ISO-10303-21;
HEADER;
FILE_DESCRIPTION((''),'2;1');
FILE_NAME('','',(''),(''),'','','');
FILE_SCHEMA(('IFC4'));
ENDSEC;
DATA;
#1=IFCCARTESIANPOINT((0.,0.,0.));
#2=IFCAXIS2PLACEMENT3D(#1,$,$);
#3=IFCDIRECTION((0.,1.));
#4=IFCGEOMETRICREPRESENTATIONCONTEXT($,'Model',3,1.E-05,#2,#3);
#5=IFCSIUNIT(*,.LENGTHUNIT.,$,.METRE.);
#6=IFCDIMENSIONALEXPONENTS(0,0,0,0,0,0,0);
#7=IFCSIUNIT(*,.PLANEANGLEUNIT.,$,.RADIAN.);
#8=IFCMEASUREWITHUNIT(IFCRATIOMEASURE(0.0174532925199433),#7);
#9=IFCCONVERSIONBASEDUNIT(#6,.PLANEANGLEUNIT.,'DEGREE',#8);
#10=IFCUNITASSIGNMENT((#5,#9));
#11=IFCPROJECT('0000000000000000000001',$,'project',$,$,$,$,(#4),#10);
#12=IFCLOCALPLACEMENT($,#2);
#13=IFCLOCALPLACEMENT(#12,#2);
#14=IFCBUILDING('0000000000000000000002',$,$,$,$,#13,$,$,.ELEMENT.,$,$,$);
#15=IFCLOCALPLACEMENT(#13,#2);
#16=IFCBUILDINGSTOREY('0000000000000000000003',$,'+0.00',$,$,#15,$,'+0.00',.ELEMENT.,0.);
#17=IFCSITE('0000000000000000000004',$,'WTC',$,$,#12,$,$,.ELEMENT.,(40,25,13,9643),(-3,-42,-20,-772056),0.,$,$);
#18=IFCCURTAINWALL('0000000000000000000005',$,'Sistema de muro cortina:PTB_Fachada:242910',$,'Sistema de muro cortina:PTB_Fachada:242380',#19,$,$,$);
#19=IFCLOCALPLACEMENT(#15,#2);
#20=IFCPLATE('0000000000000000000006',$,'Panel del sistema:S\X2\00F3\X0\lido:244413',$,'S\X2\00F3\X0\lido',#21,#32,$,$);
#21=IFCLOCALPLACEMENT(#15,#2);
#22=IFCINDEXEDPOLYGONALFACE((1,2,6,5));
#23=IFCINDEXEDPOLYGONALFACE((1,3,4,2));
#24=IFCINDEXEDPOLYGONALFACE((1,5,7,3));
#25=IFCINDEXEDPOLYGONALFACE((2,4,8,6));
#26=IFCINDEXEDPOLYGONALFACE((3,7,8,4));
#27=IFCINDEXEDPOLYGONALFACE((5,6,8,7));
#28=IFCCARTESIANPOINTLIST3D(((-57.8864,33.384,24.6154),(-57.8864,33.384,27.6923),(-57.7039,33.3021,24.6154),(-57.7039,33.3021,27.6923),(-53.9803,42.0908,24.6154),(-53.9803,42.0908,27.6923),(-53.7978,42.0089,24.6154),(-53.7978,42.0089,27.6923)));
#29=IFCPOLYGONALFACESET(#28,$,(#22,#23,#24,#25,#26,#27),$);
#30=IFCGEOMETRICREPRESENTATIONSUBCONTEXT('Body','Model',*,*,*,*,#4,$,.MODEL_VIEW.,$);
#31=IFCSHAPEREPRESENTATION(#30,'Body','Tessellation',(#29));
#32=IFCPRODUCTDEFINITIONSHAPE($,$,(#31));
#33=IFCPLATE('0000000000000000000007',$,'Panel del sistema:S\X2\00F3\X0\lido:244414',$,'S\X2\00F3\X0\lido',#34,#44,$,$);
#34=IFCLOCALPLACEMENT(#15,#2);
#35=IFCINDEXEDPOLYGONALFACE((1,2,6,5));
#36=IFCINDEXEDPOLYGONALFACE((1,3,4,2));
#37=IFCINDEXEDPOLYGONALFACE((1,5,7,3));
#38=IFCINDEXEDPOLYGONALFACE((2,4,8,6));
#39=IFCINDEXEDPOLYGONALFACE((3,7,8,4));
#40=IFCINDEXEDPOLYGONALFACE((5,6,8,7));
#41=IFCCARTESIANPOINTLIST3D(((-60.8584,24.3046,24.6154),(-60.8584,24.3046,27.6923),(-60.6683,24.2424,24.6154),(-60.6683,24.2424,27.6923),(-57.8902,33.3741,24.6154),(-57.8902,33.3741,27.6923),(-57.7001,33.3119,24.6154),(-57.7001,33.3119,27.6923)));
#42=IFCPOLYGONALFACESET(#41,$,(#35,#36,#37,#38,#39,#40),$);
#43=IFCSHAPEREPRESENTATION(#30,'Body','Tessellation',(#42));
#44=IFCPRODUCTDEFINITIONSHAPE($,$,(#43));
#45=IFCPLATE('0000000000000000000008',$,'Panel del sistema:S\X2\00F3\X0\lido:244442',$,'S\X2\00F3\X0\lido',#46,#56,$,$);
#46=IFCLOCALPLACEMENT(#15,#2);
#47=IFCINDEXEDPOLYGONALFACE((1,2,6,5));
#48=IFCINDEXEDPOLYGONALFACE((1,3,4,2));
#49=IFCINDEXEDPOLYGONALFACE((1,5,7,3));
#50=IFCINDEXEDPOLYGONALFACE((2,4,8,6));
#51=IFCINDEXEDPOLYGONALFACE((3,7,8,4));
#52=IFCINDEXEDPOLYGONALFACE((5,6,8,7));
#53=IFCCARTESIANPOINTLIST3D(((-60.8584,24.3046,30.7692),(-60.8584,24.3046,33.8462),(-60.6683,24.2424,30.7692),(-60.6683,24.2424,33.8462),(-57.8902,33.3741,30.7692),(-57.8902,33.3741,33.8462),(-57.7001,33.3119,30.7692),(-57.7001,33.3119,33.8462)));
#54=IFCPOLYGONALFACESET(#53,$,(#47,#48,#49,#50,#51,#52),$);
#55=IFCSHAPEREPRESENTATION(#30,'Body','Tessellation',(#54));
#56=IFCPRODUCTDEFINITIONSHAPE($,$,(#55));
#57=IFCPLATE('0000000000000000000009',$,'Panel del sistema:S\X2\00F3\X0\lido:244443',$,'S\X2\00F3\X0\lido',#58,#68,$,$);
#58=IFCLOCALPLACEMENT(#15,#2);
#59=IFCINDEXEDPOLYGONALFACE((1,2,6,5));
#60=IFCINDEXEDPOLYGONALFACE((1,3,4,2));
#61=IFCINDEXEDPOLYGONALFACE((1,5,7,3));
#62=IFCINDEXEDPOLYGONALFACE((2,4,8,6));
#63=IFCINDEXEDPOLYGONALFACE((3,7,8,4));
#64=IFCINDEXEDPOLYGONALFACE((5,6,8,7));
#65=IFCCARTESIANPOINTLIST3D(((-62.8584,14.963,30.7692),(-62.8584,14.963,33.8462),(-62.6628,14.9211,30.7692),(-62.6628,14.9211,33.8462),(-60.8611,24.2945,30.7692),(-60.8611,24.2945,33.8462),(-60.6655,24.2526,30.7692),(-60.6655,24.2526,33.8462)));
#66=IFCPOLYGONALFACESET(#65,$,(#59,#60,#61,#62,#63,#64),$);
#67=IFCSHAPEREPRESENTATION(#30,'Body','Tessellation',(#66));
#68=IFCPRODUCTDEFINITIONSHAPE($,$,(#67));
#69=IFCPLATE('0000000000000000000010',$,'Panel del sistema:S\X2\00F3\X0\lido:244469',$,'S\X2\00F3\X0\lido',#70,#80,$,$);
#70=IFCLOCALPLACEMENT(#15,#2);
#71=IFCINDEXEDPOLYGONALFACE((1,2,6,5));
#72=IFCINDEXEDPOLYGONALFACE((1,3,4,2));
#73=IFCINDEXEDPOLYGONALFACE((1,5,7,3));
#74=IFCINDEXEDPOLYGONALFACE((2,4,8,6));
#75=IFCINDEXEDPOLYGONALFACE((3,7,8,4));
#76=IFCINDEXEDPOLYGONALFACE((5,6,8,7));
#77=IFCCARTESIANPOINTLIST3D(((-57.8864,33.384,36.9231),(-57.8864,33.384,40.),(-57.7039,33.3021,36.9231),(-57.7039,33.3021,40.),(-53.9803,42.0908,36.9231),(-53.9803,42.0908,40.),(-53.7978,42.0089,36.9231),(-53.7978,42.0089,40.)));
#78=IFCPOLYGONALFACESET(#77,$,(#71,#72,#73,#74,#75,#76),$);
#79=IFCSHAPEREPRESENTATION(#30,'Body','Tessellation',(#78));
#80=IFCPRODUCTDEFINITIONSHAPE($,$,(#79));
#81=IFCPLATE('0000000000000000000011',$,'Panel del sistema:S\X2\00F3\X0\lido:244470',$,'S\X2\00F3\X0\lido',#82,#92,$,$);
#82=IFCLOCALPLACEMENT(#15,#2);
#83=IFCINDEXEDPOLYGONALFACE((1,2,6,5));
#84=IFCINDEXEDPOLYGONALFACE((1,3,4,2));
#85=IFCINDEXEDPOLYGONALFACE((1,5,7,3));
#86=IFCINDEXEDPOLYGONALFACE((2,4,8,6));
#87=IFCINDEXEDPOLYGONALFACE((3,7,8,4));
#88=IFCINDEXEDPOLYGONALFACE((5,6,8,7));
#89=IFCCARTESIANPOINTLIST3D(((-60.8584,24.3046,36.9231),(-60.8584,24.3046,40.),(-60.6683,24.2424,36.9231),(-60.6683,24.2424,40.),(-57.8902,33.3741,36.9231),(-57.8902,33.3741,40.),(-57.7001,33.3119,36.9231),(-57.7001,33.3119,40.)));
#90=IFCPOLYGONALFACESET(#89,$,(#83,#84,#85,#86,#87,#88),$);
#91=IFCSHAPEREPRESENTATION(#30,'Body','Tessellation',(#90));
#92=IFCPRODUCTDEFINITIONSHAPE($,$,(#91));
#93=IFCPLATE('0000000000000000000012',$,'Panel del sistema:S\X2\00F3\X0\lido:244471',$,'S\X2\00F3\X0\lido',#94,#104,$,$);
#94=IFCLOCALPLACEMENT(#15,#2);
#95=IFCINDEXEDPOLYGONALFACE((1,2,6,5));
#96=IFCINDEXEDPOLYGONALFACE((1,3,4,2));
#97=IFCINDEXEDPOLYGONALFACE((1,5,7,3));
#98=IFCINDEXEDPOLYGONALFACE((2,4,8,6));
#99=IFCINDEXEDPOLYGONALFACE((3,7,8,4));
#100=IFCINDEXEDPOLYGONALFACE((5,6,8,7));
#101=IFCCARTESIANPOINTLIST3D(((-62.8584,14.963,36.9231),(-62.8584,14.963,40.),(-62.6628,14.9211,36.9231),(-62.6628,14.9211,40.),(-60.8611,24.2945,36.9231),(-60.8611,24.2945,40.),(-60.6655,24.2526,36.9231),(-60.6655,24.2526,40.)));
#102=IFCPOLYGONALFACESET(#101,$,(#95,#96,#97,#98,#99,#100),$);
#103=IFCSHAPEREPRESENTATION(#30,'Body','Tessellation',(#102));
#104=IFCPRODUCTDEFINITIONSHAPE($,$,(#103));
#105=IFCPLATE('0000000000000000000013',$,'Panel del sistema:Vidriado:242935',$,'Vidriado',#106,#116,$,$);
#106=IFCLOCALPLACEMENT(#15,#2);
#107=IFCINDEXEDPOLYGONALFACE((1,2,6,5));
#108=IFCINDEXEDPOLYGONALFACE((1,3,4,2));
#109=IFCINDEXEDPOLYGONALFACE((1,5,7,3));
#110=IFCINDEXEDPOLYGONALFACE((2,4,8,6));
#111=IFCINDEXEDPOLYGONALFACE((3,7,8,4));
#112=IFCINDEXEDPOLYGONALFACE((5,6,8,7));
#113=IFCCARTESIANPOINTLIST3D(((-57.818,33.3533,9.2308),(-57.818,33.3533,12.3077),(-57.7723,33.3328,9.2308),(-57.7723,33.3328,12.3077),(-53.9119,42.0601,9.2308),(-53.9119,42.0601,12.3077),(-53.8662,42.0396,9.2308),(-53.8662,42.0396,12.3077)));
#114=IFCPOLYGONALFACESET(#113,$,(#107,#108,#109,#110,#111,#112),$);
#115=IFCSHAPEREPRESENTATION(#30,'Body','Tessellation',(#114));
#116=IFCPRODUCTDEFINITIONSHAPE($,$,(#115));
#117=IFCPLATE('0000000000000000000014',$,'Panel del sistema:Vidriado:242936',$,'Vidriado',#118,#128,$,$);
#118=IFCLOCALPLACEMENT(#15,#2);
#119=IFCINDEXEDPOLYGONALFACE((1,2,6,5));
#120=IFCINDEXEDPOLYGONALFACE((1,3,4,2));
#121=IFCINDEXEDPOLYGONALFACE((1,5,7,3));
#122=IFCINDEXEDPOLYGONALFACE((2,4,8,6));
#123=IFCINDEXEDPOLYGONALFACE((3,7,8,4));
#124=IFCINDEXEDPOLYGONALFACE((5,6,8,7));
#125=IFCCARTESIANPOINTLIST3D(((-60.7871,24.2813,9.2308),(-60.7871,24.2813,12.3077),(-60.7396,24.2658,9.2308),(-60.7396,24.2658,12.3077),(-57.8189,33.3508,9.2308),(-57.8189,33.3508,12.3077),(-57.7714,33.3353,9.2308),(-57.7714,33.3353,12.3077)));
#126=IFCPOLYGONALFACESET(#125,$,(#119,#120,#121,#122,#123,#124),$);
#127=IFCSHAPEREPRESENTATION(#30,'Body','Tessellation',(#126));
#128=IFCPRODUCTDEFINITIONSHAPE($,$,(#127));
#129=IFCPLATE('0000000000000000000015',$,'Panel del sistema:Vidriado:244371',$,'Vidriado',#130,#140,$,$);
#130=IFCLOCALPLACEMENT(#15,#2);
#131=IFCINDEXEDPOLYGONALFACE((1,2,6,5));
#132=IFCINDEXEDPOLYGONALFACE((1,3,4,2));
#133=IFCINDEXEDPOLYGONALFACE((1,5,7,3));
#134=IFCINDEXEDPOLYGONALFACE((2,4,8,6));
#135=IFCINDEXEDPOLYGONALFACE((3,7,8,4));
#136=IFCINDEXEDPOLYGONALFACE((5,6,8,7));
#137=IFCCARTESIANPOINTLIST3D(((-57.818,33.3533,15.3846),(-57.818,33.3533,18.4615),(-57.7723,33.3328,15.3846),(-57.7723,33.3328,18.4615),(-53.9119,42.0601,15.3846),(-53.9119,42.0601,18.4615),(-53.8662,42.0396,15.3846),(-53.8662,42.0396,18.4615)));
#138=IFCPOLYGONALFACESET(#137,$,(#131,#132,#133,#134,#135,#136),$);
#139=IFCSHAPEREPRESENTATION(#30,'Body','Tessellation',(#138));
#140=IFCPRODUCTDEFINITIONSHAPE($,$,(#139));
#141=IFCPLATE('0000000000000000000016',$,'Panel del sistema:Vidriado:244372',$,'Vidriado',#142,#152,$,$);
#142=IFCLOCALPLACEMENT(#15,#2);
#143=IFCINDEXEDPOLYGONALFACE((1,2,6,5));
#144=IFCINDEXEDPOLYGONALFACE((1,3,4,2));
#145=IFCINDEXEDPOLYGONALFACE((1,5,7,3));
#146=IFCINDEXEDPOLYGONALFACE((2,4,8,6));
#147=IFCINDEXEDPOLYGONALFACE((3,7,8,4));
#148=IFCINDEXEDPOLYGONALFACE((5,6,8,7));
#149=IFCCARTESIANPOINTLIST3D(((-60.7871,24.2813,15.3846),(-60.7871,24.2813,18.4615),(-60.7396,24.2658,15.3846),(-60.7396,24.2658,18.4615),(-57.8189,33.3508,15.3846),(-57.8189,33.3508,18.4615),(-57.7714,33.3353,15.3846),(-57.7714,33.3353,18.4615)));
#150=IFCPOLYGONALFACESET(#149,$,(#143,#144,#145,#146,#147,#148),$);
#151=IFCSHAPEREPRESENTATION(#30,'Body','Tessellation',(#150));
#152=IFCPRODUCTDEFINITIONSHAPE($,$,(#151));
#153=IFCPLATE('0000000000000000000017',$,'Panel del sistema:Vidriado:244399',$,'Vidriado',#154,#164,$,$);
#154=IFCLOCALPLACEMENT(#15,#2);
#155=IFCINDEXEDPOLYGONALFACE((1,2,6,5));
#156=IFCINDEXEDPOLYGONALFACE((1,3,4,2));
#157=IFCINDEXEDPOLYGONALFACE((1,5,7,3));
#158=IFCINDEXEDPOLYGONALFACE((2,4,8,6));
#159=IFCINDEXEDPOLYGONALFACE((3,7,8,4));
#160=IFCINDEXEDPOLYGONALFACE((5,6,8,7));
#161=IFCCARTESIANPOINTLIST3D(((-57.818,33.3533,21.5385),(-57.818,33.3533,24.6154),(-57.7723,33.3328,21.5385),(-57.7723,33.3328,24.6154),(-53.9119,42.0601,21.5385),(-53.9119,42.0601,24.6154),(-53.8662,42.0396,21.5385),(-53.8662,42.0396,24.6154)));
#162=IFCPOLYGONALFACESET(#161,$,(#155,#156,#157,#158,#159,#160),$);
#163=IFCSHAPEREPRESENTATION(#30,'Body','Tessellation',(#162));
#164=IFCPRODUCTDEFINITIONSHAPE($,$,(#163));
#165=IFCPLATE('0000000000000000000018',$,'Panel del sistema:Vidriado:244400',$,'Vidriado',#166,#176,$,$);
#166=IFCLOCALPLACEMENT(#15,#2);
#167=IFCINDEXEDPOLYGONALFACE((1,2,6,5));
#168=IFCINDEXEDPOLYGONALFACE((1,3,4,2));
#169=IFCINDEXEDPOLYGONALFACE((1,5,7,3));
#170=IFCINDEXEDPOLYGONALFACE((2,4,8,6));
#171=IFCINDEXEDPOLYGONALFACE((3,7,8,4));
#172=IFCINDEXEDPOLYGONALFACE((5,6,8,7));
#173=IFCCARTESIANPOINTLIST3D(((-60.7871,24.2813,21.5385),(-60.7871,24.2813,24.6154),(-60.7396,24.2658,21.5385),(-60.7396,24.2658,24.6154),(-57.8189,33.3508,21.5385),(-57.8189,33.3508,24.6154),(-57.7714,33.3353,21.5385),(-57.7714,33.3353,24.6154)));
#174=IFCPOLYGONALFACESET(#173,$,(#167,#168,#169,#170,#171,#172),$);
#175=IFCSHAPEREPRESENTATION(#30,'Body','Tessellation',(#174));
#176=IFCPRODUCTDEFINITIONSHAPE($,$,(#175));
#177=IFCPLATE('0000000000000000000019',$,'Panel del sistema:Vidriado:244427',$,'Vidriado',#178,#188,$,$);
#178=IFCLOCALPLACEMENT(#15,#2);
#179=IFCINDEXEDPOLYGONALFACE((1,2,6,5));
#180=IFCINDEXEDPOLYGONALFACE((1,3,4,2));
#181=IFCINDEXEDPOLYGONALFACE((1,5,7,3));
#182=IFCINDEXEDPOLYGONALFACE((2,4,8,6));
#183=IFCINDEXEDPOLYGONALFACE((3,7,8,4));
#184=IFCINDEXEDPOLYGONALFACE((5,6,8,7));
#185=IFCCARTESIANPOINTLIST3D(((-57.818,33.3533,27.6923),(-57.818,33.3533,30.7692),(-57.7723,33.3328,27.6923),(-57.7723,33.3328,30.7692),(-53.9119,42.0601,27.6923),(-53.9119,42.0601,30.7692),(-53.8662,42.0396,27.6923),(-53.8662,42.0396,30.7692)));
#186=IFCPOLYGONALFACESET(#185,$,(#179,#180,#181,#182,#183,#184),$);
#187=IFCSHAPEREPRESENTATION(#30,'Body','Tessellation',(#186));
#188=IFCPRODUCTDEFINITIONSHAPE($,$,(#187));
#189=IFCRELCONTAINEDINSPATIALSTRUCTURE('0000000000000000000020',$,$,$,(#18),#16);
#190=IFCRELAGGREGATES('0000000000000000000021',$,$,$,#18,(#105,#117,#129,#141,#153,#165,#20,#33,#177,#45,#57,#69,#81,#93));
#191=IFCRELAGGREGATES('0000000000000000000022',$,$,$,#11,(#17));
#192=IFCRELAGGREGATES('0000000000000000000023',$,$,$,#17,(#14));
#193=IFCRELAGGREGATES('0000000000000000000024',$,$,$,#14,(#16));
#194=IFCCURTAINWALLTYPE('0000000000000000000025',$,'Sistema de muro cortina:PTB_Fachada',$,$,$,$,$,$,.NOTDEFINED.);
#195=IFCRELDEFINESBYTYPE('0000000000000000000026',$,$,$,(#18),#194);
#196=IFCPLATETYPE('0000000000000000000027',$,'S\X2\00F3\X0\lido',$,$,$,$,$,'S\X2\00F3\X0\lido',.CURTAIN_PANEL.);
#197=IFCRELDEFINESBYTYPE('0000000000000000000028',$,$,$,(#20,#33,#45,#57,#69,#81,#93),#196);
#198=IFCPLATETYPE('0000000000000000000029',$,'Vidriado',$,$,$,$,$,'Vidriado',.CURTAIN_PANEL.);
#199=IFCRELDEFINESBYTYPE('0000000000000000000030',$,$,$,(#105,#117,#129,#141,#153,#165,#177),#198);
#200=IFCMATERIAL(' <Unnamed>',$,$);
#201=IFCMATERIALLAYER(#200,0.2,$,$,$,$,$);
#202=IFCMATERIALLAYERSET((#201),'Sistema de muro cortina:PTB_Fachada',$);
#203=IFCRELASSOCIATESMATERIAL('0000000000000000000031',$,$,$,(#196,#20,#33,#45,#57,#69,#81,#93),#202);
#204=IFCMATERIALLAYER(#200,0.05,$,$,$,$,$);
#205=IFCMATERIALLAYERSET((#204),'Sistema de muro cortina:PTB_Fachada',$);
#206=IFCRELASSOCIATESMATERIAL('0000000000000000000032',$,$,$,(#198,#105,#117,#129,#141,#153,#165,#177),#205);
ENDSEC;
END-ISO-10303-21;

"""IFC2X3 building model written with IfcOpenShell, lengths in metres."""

from ifc_helpers import new_model, entity, si_unit, converted_unit, direction, frame, frame_2d, origin, origin_2d_with_axis, place, context, subcontext, project, spatial, rectangle, extrude, source, transform, mapped, material, layer, layer_set, layer_usage, type_object, type_shapes, element, aggregate, save


model = new_model("IFC2X3")

# Units and contexts
model_context = context("Model", 3, precision=1e-05, world=origin(), true_north=direction((0.0, 1.0)))
body_context = subcontext(model_context, "Body", "Model", "MODEL_VIEW")
ifc_project = project(units=[si_unit("LENGTHUNIT", "METRE"), converted_unit("PLANEANGLEUNIT", "DEGREE", entity("IfcRatioMeasure", 0.0174532925199433), si_unit("PLANEANGLEUNIT", "RADIAN"), dimensions=[0, 0, 0, 0, 0, 0, 0])], contexts=[model_context])

# Site, building, storey
site_placement = place(None, origin())
site = spatial("IfcSite", under=ifc_project, at=site_placement, Name="WTC", CompositionType="ELEMENT", RefLatitude=(40, 25, 13, 9643), RefLongitude=(-3, -42, -20, -772056), RefElevation=0.0)
building_placement = place(site_placement, origin())
building = spatial("IfcBuilding", under=site, at=building_placement, CompositionType="ELEMENT")
storey_placement = place(building_placement, origin())
storey = spatial("IfcBuildingStorey", under=building, at=storey_placement, Name="+0.00", LongName="+0.00", CompositionType="ELEMENT", Elevation=0.0)

# Curtain wall, plates
curtain_wall_type = type_object("IfcCurtainWallType", Name="Sistema de muro cortina:PTB_Fachada", PredefinedType="NOTDEFINED")
curtain_wall_placement = place(storey_placement, origin())
curtain_wall = element("IfcCurtainWall", 1, at=curtain_wall_placement, inside=storey, type_object=curtain_wall_type, Name="Sistema de muro cortina:PTB_Fachada:242910", ObjectType="Sistema de muro cortina:PTB_Fachada:242380")
ifc_material_1 = material(Name=" <Unnamed>")
ifc_layer_1 = layer(ifc_material_1, 0.2)
ifc_layer_set_1 = layer_set([ifc_layer_1], Name="Sistema de muro cortina:PTB_Fachada")
plate_type_1 = type_object("IfcPlateType", Name="Sólido", ElementType="Sólido", PredefinedType="CURTAIN_PANEL", material=ifc_layer_set_1)
shared_shape_1 = source(origin(), body_context, "Body", "SweptSolid", [
    extrude(rectangle(XDim=0.2, YDim=9.5428, at=frame_2d((0.0, 0.0), x_axis=(1.0, 0.0))), frame((0.0, 0.0, 0.0), z_axis=(0.0, 0.0, 1.0), x_axis=(0.0, 1.0, 0.0)), (0.0, 0.0, 1.0), 3.0769),
])
type_shapes(plate_type_1, [shared_shape_1])
ifc_layer_usage_1 = layer_usage(ifc_layer_set_1, "AXIS3", "POSITIVE", 0.0)
plate_1_placement = place(curtain_wall_placement, frame((-55.8421, 37.6964, 24.6154), z_axis=(0.0, 0.0, 1.0), x_axis=(-0.409321, -0.91239, 0.0)))
plate_1 = element("IfcPlate", 2, at=plate_1_placement, type_object=plate_type_1, material=ifc_layer_usage_1, Name="Panel del sistema:Sólido:244413", ObjectType="Sólido", context=body_context, shape_type="MappedRepresentation", body=[
    mapped(shared_shape_1, transform((0.0, 0.0, 0.0), scale=1.0)),
])
ifc_layer_usage_2 = layer_usage(ifc_layer_set_1, "AXIS3", "POSITIVE", 0.0)
plate_2_placement = place(curtain_wall_placement, frame((-59.2792, 28.8083, 24.6154), z_axis=(0.0, 0.0, 1.0), x_axis=(-0.311036, -0.950398, 0.0)))
plate_2 = element("IfcPlate", 3, at=plate_2_placement, type_object=plate_type_1, material=ifc_layer_usage_2, Name="Panel del sistema:Sólido:244414", ObjectType="Sólido", context=body_context, shape_type="MappedRepresentation", body=[
    mapped(shared_shape_1, transform((0.0, 0.0, 0.0), scale=1.0)),
])
ifc_layer_usage_3 = layer_usage(ifc_layer_set_1, "AXIS3", "POSITIVE", 0.0)
plate_3_placement = place(curtain_wall_placement, frame((-59.2792, 28.8083, 30.7692), z_axis=(0.0, 0.0, 1.0), x_axis=(-0.311036, -0.950398, 0.0)))
plate_3 = element("IfcPlate", 4, at=plate_3_placement, type_object=plate_type_1, material=ifc_layer_usage_3, Name="Panel del sistema:Sólido:244442", ObjectType="Sólido", context=body_context, shape_type="MappedRepresentation", body=[
    mapped(shared_shape_1, transform((0.0, 0.0, 0.0), scale=1.0)),
])
ifc_layer_usage_4 = layer_usage(ifc_layer_set_1, "AXIS3", "POSITIVE", 0.0)
plate_4_placement = place(curtain_wall_placement, frame((-61.762, 19.6078, 30.7692), z_axis=(0.0, 0.0, 1.0), x_axis=(-0.209296, -0.977852, 0.0)))
plate_4 = element("IfcPlate", 5, at=plate_4_placement, type_object=plate_type_1, material=ifc_layer_usage_4, Name="Panel del sistema:Sólido:244443", ObjectType="Sólido", context=body_context, shape_type="MappedRepresentation", body=[
    mapped(shared_shape_1, transform((0.0, 0.0, 0.0), scale=1.0)),
])
ifc_layer_usage_5 = layer_usage(ifc_layer_set_1, "AXIS3", "POSITIVE", 0.0)
plate_5_placement = place(curtain_wall_placement, frame((-55.8421, 37.6964, 36.9231), z_axis=(0.0, 0.0, 1.0), x_axis=(-0.409321, -0.91239, 0.0)))
plate_5 = element("IfcPlate", 6, at=plate_5_placement, type_object=plate_type_1, material=ifc_layer_usage_5, Name="Panel del sistema:Sólido:244469", ObjectType="Sólido", context=body_context, shape_type="MappedRepresentation", body=[
    mapped(shared_shape_1, transform((0.0, 0.0, 0.0), scale=1.0)),
])
ifc_layer_usage_6 = layer_usage(ifc_layer_set_1, "AXIS3", "POSITIVE", 0.0)
plate_6_placement = place(curtain_wall_placement, frame((-59.2792, 28.8083, 36.9231), z_axis=(0.0, 0.0, 1.0), x_axis=(-0.311036, -0.950398, 0.0)))
plate_6 = element("IfcPlate", 7, at=plate_6_placement, type_object=plate_type_1, material=ifc_layer_usage_6, Name="Panel del sistema:Sólido:244470", ObjectType="Sólido", context=body_context, shape_type="MappedRepresentation", body=[
    mapped(shared_shape_1, transform((0.0, 0.0, 0.0), scale=1.0)),
])
ifc_layer_usage_7 = layer_usage(ifc_layer_set_1, "AXIS3", "POSITIVE", 0.0)
plate_7_placement = place(curtain_wall_placement, frame((-61.762, 19.6078, 36.9231), z_axis=(0.0, 0.0, 1.0), x_axis=(-0.209296, -0.977852, 0.0)))
plate_7 = element("IfcPlate", 8, at=plate_7_placement, type_object=plate_type_1, material=ifc_layer_usage_7, Name="Panel del sistema:Sólido:244471", ObjectType="Sólido", context=body_context, shape_type="MappedRepresentation", body=[
    mapped(shared_shape_1, transform((0.0, 0.0, 0.0), scale=1.0)),
])
ifc_layer_2 = layer(ifc_material_1, 0.05)
ifc_layer_set_2 = layer_set([ifc_layer_2], Name="Sistema de muro cortina:PTB_Fachada")
ifc_layer_usage_8 = layer_usage(ifc_layer_set_2, "AXIS3", "POSITIVE", 0.0)
plate_type_2 = type_object("IfcPlateType", Name="Vidriado", ElementType="Vidriado", PredefinedType="CURTAIN_PANEL", material=ifc_layer_set_2)
shared_shape_2 = source(origin(), body_context, "Body", "SweptSolid", [
    extrude(rectangle(XDim=0.05, YDim=9.5428, at=origin_2d_with_axis()), frame((0.0, 0.0, 0.0), z_axis=(0.0, 0.0, 1.0), x_axis=(0.0, 1.0, 0.0)), (0.0, 0.0, 1.0), 3.0769),
])
type_shapes(plate_type_2, [shared_shape_2])
plate_8_placement = place(curtain_wall_placement, frame((-55.8421, 37.6964, 9.2308), z_axis=(0.0, 0.0, 1.0), x_axis=(-0.409321, -0.91239, 0.0)))
plate_8 = element("IfcPlate", 9, at=plate_8_placement, type_object=plate_type_2, material=ifc_layer_usage_8, Name="Panel del sistema:Vidriado:242935", ObjectType="Vidriado", context=body_context, shape_type="MappedRepresentation", body=[
    mapped(shared_shape_2, transform((0.0, 0.0, 0.0), scale=1.0)),
])
ifc_layer_usage_9 = layer_usage(ifc_layer_set_2, "AXIS3", "POSITIVE", 0.0)
plate_9_placement = place(curtain_wall_placement, frame((-59.2792, 28.8083, 9.2308), z_axis=(0.0, 0.0, 1.0), x_axis=(-0.311036, -0.950398, 0.0)))
plate_9 = element("IfcPlate", 10, at=plate_9_placement, type_object=plate_type_2, material=ifc_layer_usage_9, Name="Panel del sistema:Vidriado:242936", ObjectType="Vidriado", context=body_context, shape_type="MappedRepresentation", body=[
    mapped(shared_shape_2, transform((0.0, 0.0, 0.0), scale=1.0)),
])
ifc_layer_usage_10 = layer_usage(ifc_layer_set_2, "AXIS3", "POSITIVE", 0.0)
plate_10_placement = place(curtain_wall_placement, frame((-55.8421, 37.6964, 15.3846), z_axis=(0.0, 0.0, 1.0), x_axis=(-0.409321, -0.91239, 0.0)))
plate_10 = element("IfcPlate", 11, at=plate_10_placement, type_object=plate_type_2, material=ifc_layer_usage_10, Name="Panel del sistema:Vidriado:244371", ObjectType="Vidriado", context=body_context, shape_type="MappedRepresentation", body=[
    mapped(shared_shape_2, transform((0.0, 0.0, 0.0), scale=1.0)),
])
ifc_layer_usage_11 = layer_usage(ifc_layer_set_2, "AXIS3", "POSITIVE", 0.0)
plate_11_placement = place(curtain_wall_placement, frame((-59.2792, 28.8083, 15.3846), z_axis=(0.0, 0.0, 1.0), x_axis=(-0.311036, -0.950398, 0.0)))
plate_11 = element("IfcPlate", 12, at=plate_11_placement, type_object=plate_type_2, material=ifc_layer_usage_11, Name="Panel del sistema:Vidriado:244372", ObjectType="Vidriado", context=body_context, shape_type="MappedRepresentation", body=[
    mapped(shared_shape_2, transform((0.0, 0.0, 0.0), scale=1.0)),
])
ifc_layer_usage_12 = layer_usage(ifc_layer_set_2, "AXIS3", "POSITIVE", 0.0)
plate_12_placement = place(curtain_wall_placement, frame((-55.8421, 37.6964, 21.5385), z_axis=(0.0, 0.0, 1.0), x_axis=(-0.409321, -0.91239, 0.0)))
plate_12 = element("IfcPlate", 13, at=plate_12_placement, type_object=plate_type_2, material=ifc_layer_usage_12, Name="Panel del sistema:Vidriado:244399", ObjectType="Vidriado", context=body_context, shape_type="MappedRepresentation", body=[
    mapped(shared_shape_2, transform((0.0, 0.0, 0.0), scale=1.0)),
])
ifc_layer_usage_13 = layer_usage(ifc_layer_set_2, "AXIS3", "POSITIVE", 0.0)
plate_13_placement = place(curtain_wall_placement, frame((-59.2792, 28.8083, 21.5385), z_axis=(0.0, 0.0, 1.0), x_axis=(-0.311036, -0.950398, 0.0)))
plate_13 = element("IfcPlate", 14, at=plate_13_placement, type_object=plate_type_2, material=ifc_layer_usage_13, Name="Panel del sistema:Vidriado:244400", ObjectType="Vidriado", context=body_context, shape_type="MappedRepresentation", body=[
    mapped(shared_shape_2, transform((0.0, 0.0, 0.0), scale=1.0)),
])
ifc_layer_usage_14 = layer_usage(ifc_layer_set_2, "AXIS3", "POSITIVE", 0.0)
plate_14_placement = place(curtain_wall_placement, frame((-55.8421, 37.6964, 27.6923), z_axis=(0.0, 0.0, 1.0), x_axis=(-0.409321, -0.91239, 0.0)))
plate_14 = element("IfcPlate", 15, at=plate_14_placement, type_object=plate_type_2, material=ifc_layer_usage_14, Name="Panel del sistema:Vidriado:244427", ObjectType="Vidriado", context=body_context, shape_type="MappedRepresentation", body=[
    mapped(shared_shape_2, transform((0.0, 0.0, 0.0), scale=1.0)),
])
aggregate(curtain_wall, [plate_8, plate_9, plate_10, plate_11, plate_12, plate_13, plate_1, plate_2, plate_14, plate_3, plate_4, plate_5, plate_6, plate_7])

save(model, "model.ifc")
